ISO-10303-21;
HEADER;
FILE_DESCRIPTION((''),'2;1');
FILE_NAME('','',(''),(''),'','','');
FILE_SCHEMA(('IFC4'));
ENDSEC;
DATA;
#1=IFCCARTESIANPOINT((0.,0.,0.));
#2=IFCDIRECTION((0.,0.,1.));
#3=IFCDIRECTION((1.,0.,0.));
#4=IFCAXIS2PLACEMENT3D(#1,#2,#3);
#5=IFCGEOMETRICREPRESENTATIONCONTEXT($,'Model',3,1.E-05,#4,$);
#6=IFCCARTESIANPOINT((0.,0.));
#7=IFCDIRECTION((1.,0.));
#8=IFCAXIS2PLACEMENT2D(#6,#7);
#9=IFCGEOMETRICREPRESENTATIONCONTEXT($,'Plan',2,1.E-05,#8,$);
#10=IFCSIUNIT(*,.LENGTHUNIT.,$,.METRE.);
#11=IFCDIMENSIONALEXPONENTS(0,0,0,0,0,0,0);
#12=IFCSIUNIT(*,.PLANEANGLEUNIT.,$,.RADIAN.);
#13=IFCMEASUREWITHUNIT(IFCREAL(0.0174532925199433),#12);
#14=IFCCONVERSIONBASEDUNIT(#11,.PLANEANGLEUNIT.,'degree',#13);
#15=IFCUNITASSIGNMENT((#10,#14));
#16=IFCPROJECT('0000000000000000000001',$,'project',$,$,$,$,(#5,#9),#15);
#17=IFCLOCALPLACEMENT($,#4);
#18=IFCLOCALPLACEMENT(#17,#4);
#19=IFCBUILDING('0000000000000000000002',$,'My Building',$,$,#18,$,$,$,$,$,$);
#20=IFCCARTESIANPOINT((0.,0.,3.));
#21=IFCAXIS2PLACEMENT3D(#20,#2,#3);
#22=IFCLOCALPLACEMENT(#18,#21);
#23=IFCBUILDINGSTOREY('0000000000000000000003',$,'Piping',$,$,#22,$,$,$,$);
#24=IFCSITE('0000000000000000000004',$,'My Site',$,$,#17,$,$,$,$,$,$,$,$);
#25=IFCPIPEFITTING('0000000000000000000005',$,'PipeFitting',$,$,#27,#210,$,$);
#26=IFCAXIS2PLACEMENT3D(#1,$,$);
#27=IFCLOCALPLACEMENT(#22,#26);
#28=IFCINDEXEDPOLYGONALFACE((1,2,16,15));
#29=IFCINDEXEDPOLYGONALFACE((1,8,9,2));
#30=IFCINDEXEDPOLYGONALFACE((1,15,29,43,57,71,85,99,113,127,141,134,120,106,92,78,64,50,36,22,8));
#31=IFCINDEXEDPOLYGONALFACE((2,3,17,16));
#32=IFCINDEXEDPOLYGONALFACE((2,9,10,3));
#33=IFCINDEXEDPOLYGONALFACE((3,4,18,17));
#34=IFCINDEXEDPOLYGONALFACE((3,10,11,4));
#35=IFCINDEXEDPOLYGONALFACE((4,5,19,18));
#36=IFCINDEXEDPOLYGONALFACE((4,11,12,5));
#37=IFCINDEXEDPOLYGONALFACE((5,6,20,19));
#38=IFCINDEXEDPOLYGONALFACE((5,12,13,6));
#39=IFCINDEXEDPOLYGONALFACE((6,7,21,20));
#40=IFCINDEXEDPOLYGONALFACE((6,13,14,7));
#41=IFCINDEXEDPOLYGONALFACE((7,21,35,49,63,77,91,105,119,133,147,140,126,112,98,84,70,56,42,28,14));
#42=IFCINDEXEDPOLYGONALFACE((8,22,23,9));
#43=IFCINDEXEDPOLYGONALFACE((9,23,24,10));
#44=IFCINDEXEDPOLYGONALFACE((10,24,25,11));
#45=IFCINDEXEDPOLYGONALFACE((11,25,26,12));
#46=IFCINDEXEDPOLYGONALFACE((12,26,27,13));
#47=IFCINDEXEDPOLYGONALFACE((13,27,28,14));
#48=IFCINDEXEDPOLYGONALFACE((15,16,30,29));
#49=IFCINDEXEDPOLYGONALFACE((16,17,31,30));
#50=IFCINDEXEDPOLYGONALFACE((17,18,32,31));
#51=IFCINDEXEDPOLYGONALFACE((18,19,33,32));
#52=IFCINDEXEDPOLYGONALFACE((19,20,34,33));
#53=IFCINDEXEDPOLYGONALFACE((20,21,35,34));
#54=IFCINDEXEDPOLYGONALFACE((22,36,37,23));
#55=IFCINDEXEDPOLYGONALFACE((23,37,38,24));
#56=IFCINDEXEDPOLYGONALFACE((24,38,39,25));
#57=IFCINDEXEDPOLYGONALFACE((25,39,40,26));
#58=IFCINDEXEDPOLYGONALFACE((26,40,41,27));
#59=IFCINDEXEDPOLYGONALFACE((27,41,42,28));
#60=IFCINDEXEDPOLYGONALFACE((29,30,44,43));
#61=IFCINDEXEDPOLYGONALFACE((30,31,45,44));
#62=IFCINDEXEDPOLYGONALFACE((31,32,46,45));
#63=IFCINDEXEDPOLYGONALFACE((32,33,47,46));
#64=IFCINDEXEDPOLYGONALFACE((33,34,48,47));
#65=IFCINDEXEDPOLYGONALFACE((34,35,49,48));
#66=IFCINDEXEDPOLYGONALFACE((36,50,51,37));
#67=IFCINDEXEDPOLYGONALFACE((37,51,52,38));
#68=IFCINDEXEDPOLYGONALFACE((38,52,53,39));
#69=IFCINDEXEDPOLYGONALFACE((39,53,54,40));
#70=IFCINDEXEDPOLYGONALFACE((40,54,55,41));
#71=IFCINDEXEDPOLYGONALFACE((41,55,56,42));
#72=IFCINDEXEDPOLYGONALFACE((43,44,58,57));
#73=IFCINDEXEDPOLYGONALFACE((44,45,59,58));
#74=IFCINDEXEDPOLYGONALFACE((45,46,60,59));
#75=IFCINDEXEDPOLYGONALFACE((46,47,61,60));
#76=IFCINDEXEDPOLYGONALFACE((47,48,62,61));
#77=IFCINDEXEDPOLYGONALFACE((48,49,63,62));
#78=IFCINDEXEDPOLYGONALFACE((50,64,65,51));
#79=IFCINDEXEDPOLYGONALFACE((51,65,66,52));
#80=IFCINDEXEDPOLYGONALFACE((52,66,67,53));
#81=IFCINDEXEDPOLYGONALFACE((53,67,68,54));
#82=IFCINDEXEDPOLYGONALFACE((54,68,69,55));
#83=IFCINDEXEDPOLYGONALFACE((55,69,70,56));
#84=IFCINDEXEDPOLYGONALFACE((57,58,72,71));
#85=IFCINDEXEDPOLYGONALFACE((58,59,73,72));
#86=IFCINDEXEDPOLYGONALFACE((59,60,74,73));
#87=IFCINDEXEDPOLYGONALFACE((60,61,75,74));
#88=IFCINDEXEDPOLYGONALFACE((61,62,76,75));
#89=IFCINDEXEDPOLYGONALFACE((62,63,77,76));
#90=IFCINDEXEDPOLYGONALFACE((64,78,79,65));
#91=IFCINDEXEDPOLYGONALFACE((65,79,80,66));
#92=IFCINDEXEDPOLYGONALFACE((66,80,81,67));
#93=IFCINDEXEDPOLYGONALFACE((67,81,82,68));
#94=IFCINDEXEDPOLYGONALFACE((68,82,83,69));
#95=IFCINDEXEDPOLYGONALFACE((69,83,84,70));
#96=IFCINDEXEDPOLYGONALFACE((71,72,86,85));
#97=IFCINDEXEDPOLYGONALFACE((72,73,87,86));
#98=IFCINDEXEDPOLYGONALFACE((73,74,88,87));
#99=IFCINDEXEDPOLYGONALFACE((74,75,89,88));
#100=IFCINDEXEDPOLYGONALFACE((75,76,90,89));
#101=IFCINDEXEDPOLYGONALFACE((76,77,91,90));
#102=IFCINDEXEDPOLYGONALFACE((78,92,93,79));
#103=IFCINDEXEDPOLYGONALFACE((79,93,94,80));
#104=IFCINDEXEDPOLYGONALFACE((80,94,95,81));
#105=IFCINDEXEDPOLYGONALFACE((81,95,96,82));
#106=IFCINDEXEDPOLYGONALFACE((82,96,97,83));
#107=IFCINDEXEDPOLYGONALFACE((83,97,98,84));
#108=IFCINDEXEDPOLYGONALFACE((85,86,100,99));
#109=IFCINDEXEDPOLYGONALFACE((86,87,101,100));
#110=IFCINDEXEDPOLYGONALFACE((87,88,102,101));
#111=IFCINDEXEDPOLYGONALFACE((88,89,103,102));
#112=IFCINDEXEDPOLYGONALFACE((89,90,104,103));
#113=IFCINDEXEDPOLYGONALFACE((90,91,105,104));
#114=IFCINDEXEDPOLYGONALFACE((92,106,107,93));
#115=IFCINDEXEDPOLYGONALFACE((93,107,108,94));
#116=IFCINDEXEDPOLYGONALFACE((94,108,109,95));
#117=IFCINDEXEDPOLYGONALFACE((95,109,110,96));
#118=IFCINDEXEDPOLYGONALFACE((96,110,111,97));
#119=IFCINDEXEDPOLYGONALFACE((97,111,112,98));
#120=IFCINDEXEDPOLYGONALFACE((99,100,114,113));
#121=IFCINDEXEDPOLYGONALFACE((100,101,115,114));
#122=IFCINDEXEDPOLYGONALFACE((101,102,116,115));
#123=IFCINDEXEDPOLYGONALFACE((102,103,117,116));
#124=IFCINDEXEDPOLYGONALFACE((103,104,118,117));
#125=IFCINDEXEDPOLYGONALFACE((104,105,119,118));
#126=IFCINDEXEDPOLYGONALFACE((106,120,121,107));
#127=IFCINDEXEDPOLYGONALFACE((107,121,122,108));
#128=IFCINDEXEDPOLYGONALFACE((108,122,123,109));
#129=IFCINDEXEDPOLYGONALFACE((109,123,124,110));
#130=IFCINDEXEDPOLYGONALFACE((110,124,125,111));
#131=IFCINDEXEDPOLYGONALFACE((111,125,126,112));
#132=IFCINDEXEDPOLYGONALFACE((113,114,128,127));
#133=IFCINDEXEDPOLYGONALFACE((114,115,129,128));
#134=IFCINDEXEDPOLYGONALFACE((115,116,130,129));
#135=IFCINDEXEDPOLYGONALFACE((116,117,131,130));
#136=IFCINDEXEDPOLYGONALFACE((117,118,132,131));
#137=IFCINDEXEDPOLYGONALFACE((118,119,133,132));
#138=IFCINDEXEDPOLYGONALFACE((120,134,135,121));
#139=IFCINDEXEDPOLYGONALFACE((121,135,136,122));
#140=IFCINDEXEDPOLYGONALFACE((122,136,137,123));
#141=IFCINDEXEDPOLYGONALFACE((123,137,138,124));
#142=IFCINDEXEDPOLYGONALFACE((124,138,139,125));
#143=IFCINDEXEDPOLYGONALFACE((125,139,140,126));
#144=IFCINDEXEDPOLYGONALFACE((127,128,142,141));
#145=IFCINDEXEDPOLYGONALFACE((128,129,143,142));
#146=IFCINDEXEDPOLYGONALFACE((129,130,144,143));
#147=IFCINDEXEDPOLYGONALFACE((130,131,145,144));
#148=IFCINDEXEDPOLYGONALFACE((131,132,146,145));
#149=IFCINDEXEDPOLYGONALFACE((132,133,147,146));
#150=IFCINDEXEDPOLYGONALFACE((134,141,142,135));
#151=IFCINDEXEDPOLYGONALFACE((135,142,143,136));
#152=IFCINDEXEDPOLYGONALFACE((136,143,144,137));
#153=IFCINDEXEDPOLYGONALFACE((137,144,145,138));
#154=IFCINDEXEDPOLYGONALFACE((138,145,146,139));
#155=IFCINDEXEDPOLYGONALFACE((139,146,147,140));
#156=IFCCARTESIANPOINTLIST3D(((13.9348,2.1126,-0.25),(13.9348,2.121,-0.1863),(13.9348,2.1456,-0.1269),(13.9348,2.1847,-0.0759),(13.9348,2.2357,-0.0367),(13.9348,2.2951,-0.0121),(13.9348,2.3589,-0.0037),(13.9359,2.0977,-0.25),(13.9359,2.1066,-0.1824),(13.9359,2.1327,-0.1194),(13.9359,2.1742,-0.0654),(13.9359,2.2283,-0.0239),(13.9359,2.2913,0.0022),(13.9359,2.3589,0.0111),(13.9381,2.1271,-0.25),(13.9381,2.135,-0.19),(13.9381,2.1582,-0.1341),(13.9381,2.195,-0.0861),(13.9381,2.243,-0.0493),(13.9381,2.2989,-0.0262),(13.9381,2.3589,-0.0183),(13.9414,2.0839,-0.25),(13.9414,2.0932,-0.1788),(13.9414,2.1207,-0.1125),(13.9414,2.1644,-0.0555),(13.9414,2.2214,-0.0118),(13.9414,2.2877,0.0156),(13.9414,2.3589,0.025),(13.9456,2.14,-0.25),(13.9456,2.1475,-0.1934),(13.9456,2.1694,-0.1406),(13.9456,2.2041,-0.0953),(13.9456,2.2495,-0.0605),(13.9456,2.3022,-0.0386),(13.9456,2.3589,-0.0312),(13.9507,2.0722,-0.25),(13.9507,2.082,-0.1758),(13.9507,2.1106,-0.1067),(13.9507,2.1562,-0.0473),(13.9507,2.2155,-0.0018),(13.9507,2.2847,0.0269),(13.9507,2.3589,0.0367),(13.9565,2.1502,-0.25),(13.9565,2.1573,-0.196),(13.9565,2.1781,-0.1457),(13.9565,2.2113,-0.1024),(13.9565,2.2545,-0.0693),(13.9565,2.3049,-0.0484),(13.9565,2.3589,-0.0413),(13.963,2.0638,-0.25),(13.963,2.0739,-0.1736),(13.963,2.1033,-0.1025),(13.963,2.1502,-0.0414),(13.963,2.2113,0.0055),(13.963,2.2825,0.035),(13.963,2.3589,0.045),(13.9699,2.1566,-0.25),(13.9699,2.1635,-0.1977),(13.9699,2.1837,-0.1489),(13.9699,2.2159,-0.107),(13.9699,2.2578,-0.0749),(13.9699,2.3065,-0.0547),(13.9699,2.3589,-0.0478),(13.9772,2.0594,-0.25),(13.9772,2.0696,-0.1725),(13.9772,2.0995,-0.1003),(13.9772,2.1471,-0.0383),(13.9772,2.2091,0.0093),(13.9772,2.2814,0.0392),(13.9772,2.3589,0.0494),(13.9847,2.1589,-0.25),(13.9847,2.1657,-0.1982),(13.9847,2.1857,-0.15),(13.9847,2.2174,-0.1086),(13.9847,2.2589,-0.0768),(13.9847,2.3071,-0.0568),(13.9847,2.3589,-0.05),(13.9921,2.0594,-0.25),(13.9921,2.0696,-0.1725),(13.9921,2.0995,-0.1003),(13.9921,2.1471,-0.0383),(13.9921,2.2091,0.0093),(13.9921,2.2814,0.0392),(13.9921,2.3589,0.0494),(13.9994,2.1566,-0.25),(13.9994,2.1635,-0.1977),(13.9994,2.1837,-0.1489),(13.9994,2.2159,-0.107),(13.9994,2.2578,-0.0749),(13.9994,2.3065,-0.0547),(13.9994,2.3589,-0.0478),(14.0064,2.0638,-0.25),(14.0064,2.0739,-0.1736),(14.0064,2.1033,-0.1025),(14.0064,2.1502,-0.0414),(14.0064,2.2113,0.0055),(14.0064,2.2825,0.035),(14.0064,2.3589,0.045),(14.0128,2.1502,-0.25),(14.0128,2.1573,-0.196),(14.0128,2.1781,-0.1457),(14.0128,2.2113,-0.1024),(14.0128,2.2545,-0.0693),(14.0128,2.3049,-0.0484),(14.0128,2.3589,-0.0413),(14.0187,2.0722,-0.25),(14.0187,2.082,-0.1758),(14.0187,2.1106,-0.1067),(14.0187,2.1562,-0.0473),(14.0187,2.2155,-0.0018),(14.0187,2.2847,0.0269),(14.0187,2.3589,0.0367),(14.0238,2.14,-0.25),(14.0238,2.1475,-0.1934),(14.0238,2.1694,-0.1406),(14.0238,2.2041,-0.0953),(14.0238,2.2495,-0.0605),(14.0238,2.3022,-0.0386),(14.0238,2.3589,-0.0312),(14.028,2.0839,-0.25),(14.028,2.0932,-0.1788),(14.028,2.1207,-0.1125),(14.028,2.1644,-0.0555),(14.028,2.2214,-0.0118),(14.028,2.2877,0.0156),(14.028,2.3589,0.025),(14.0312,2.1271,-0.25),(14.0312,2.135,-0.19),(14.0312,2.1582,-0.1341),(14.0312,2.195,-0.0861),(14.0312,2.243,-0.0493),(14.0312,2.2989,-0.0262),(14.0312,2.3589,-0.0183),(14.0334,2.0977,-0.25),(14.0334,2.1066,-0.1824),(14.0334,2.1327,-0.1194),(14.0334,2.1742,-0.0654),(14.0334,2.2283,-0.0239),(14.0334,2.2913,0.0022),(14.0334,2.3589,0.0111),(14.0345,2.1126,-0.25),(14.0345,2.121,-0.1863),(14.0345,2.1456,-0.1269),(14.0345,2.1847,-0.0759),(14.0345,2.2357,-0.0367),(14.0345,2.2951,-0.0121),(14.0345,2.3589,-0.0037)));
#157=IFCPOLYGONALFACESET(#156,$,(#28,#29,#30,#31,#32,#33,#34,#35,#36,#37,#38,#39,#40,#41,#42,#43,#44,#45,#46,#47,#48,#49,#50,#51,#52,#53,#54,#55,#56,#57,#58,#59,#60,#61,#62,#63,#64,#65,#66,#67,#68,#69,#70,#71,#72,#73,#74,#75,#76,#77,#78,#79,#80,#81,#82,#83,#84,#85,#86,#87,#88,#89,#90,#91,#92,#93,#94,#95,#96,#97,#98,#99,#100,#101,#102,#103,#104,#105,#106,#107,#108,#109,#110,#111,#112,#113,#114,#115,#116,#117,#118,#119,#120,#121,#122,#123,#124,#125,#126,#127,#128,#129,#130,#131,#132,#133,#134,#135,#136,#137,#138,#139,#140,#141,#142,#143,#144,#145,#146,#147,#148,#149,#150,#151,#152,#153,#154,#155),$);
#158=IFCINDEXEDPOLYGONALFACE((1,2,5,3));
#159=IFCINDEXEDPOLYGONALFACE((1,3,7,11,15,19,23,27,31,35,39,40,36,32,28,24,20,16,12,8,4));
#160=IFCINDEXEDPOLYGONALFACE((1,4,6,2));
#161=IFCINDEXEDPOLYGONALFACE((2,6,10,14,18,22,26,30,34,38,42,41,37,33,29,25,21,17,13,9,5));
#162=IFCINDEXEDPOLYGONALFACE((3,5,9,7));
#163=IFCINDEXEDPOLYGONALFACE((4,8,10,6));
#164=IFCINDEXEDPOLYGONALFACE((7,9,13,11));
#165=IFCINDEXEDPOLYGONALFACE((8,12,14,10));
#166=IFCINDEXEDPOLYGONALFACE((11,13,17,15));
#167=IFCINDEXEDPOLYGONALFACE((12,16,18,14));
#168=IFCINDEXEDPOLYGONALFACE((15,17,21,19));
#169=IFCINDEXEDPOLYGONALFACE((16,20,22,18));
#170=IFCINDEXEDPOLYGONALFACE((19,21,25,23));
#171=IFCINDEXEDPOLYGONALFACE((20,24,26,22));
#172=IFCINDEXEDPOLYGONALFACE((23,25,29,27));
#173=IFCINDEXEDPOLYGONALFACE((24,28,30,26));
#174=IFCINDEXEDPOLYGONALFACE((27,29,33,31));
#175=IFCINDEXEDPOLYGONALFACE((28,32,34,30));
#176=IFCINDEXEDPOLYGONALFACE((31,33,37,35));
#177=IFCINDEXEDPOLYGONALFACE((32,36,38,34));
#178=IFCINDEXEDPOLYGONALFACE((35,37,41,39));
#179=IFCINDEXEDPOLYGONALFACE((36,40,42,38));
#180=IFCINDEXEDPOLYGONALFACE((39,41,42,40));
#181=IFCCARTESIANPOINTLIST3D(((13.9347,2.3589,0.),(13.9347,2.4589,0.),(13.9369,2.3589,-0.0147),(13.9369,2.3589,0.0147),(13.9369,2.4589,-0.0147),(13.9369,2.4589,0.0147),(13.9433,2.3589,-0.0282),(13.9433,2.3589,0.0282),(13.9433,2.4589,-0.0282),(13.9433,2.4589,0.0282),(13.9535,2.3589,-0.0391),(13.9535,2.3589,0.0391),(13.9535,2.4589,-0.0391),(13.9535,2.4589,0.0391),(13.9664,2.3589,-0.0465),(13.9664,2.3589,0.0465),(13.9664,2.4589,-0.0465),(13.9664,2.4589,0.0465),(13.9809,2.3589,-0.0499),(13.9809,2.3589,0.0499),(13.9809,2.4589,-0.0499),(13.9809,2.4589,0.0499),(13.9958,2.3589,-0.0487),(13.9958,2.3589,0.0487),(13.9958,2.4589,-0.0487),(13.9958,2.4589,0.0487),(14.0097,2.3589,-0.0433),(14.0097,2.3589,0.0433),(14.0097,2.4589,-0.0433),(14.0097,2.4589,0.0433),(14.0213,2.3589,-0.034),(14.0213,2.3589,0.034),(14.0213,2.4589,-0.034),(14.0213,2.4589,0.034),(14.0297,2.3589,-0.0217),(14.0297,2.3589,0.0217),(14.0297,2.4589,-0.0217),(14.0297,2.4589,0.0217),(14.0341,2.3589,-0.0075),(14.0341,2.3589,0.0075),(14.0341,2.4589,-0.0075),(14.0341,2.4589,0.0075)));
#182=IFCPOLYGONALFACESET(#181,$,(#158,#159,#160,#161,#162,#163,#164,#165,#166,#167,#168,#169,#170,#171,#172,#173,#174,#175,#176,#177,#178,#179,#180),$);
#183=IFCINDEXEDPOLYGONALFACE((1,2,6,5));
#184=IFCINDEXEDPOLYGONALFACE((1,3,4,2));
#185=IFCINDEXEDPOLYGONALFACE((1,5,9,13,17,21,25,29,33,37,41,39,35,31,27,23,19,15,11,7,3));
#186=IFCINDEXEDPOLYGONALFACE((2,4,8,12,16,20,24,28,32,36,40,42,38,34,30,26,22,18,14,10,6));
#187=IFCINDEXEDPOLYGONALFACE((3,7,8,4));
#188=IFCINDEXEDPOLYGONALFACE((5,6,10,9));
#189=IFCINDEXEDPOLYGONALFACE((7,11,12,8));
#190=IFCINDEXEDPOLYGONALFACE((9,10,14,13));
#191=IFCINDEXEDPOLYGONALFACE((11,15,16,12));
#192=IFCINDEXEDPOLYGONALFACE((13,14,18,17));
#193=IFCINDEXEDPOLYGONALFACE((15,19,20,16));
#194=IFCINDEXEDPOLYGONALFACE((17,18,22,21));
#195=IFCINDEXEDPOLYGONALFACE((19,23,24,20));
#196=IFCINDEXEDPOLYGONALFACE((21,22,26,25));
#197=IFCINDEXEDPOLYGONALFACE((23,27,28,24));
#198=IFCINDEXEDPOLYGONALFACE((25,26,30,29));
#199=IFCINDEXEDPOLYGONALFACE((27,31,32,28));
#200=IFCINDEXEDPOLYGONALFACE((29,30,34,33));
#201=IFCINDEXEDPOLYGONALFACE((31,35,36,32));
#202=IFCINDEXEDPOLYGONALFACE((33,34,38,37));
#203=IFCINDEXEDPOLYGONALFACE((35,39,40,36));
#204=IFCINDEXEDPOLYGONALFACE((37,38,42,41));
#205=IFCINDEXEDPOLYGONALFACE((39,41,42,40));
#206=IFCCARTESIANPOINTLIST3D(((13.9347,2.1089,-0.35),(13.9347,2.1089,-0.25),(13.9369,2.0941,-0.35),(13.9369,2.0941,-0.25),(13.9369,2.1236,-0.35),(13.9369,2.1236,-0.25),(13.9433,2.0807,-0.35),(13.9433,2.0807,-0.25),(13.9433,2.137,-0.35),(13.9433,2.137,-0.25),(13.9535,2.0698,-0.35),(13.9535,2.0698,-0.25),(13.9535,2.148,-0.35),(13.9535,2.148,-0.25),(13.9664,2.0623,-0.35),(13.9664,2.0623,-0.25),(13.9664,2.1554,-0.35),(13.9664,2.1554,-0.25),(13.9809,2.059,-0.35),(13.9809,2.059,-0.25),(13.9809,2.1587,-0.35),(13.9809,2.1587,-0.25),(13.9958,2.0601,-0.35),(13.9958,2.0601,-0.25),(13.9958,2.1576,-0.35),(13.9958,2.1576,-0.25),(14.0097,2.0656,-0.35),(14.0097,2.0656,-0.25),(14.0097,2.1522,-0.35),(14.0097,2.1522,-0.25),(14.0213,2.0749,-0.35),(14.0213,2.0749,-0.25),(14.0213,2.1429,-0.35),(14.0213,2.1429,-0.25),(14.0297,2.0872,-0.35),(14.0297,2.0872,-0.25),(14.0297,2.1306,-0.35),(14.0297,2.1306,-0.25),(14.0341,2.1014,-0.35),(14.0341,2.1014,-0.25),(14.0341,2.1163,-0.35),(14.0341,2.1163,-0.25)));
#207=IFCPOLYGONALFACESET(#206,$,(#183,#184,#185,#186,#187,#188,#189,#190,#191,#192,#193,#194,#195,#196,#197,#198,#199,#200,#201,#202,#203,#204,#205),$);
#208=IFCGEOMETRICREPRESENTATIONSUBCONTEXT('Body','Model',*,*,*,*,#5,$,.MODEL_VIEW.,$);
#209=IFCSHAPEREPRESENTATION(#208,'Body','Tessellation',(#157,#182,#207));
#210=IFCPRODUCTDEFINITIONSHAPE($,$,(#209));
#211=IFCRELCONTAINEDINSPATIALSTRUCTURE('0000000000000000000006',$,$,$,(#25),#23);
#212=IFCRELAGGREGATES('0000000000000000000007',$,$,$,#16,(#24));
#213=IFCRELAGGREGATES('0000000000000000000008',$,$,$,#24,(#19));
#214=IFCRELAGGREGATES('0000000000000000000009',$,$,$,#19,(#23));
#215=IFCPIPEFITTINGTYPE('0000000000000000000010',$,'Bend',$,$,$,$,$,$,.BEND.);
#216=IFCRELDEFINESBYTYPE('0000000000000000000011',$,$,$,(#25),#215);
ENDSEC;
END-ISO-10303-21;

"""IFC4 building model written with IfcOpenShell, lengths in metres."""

from ifc_helpers import new_model, entity, si_unit, converted_unit, frame, origin_with_axes, origin_2d_with_axis, place, context, subcontext, project, spatial, circle, extrude, source, transform, mapped, type_object, type_shapes, element, save


model = new_model("IFC4")

# Units and contexts
model_context = context("Model", 3, precision=1e-05, world=origin_with_axes())
plan_context = context("Plan", 2, precision=1e-05, world=origin_2d_with_axis())
body_context = subcontext(model_context, "Body", "Model", "MODEL_VIEW")
ifc_project = project(units=[si_unit("LENGTHUNIT", "METRE"), converted_unit("PLANEANGLEUNIT", "degree", entity("IfcReal", 0.0174532925199433), si_unit("PLANEANGLEUNIT", "RADIAN"), dimensions=[0, 0, 0, 0, 0, 0, 0])], contexts=[model_context, plan_context])

# Site, building, storey
site_placement = place(None, origin_with_axes())
site = spatial("IfcSite", under=ifc_project, at=site_placement, Name="My Site")
building_placement = place(site_placement, origin_with_axes())
building = spatial("IfcBuilding", under=site, at=building_placement, Name="My Building")
storey_placement = place(building_placement, frame((0.0, 0.0, 3.0), z_axis=(0.0, 0.0, 1.0), x_axis=(1.0, 0.0, 0.0)))
storey = spatial("IfcBuildingStorey", under=building, at=storey_placement, Name="Piping")

# Shared definitions
pipe_fitting_type = type_object("IfcPipeFittingType", Name="Bend", PredefinedType="BEND")
shared_shape = source(origin_with_axes(), body_context, "Body", "SolidModel", [
    entity("IfcSweptDiskSolid", entity("IfcIndexedPolyCurve", entity("IfcCartesianPointList3D", [[0.0, 0.0, -0.1], [0.0, -0.0732, -0.2768], [0.0, -0.25, -0.35]]), [entity("IfcArcIndex", [1, 2, 3])]), 0.05),
    extrude(circle(Radius=0.05), origin_with_axes(), (0.0, 0.0, -1.0), 0.1),
    extrude(circle(Radius=0.05), frame((0.0, -0.25, -0.35), z_axis=(0.0, -1.0, 0.0), x_axis=(1.0, 0.0, 0.0)), (0.0, 0.0, 1.0), 0.1),
])
type_shapes(pipe_fitting_type, [shared_shape])

# Pipe fitting
for number, where, z_axis, x_axis, name in (
    (1, (13.9847, 2.4589, 0.0), (0.0, 1.0, 0.0), (-1.0, 0.0, 0.0), "PipeFitting"),
):
    element("IfcPipeFitting", number, at=place(storey_placement, frame(where, z_axis=z_axis, x_axis=x_axis)), inside=storey, type_object=pipe_fitting_type, Name=name, context=body_context, shape_type="MappedRepresentation", body=[
        mapped(shared_shape, transform((0.0, 0.0, 0.0), x_axis=(1.0, 0.0, 0.0), y_axis=(0.0, 1.0, 0.0), z_axis=(0.0, 0.0, 1.0), scale=1.0)),
    ])

save(model, "model.ifc")
